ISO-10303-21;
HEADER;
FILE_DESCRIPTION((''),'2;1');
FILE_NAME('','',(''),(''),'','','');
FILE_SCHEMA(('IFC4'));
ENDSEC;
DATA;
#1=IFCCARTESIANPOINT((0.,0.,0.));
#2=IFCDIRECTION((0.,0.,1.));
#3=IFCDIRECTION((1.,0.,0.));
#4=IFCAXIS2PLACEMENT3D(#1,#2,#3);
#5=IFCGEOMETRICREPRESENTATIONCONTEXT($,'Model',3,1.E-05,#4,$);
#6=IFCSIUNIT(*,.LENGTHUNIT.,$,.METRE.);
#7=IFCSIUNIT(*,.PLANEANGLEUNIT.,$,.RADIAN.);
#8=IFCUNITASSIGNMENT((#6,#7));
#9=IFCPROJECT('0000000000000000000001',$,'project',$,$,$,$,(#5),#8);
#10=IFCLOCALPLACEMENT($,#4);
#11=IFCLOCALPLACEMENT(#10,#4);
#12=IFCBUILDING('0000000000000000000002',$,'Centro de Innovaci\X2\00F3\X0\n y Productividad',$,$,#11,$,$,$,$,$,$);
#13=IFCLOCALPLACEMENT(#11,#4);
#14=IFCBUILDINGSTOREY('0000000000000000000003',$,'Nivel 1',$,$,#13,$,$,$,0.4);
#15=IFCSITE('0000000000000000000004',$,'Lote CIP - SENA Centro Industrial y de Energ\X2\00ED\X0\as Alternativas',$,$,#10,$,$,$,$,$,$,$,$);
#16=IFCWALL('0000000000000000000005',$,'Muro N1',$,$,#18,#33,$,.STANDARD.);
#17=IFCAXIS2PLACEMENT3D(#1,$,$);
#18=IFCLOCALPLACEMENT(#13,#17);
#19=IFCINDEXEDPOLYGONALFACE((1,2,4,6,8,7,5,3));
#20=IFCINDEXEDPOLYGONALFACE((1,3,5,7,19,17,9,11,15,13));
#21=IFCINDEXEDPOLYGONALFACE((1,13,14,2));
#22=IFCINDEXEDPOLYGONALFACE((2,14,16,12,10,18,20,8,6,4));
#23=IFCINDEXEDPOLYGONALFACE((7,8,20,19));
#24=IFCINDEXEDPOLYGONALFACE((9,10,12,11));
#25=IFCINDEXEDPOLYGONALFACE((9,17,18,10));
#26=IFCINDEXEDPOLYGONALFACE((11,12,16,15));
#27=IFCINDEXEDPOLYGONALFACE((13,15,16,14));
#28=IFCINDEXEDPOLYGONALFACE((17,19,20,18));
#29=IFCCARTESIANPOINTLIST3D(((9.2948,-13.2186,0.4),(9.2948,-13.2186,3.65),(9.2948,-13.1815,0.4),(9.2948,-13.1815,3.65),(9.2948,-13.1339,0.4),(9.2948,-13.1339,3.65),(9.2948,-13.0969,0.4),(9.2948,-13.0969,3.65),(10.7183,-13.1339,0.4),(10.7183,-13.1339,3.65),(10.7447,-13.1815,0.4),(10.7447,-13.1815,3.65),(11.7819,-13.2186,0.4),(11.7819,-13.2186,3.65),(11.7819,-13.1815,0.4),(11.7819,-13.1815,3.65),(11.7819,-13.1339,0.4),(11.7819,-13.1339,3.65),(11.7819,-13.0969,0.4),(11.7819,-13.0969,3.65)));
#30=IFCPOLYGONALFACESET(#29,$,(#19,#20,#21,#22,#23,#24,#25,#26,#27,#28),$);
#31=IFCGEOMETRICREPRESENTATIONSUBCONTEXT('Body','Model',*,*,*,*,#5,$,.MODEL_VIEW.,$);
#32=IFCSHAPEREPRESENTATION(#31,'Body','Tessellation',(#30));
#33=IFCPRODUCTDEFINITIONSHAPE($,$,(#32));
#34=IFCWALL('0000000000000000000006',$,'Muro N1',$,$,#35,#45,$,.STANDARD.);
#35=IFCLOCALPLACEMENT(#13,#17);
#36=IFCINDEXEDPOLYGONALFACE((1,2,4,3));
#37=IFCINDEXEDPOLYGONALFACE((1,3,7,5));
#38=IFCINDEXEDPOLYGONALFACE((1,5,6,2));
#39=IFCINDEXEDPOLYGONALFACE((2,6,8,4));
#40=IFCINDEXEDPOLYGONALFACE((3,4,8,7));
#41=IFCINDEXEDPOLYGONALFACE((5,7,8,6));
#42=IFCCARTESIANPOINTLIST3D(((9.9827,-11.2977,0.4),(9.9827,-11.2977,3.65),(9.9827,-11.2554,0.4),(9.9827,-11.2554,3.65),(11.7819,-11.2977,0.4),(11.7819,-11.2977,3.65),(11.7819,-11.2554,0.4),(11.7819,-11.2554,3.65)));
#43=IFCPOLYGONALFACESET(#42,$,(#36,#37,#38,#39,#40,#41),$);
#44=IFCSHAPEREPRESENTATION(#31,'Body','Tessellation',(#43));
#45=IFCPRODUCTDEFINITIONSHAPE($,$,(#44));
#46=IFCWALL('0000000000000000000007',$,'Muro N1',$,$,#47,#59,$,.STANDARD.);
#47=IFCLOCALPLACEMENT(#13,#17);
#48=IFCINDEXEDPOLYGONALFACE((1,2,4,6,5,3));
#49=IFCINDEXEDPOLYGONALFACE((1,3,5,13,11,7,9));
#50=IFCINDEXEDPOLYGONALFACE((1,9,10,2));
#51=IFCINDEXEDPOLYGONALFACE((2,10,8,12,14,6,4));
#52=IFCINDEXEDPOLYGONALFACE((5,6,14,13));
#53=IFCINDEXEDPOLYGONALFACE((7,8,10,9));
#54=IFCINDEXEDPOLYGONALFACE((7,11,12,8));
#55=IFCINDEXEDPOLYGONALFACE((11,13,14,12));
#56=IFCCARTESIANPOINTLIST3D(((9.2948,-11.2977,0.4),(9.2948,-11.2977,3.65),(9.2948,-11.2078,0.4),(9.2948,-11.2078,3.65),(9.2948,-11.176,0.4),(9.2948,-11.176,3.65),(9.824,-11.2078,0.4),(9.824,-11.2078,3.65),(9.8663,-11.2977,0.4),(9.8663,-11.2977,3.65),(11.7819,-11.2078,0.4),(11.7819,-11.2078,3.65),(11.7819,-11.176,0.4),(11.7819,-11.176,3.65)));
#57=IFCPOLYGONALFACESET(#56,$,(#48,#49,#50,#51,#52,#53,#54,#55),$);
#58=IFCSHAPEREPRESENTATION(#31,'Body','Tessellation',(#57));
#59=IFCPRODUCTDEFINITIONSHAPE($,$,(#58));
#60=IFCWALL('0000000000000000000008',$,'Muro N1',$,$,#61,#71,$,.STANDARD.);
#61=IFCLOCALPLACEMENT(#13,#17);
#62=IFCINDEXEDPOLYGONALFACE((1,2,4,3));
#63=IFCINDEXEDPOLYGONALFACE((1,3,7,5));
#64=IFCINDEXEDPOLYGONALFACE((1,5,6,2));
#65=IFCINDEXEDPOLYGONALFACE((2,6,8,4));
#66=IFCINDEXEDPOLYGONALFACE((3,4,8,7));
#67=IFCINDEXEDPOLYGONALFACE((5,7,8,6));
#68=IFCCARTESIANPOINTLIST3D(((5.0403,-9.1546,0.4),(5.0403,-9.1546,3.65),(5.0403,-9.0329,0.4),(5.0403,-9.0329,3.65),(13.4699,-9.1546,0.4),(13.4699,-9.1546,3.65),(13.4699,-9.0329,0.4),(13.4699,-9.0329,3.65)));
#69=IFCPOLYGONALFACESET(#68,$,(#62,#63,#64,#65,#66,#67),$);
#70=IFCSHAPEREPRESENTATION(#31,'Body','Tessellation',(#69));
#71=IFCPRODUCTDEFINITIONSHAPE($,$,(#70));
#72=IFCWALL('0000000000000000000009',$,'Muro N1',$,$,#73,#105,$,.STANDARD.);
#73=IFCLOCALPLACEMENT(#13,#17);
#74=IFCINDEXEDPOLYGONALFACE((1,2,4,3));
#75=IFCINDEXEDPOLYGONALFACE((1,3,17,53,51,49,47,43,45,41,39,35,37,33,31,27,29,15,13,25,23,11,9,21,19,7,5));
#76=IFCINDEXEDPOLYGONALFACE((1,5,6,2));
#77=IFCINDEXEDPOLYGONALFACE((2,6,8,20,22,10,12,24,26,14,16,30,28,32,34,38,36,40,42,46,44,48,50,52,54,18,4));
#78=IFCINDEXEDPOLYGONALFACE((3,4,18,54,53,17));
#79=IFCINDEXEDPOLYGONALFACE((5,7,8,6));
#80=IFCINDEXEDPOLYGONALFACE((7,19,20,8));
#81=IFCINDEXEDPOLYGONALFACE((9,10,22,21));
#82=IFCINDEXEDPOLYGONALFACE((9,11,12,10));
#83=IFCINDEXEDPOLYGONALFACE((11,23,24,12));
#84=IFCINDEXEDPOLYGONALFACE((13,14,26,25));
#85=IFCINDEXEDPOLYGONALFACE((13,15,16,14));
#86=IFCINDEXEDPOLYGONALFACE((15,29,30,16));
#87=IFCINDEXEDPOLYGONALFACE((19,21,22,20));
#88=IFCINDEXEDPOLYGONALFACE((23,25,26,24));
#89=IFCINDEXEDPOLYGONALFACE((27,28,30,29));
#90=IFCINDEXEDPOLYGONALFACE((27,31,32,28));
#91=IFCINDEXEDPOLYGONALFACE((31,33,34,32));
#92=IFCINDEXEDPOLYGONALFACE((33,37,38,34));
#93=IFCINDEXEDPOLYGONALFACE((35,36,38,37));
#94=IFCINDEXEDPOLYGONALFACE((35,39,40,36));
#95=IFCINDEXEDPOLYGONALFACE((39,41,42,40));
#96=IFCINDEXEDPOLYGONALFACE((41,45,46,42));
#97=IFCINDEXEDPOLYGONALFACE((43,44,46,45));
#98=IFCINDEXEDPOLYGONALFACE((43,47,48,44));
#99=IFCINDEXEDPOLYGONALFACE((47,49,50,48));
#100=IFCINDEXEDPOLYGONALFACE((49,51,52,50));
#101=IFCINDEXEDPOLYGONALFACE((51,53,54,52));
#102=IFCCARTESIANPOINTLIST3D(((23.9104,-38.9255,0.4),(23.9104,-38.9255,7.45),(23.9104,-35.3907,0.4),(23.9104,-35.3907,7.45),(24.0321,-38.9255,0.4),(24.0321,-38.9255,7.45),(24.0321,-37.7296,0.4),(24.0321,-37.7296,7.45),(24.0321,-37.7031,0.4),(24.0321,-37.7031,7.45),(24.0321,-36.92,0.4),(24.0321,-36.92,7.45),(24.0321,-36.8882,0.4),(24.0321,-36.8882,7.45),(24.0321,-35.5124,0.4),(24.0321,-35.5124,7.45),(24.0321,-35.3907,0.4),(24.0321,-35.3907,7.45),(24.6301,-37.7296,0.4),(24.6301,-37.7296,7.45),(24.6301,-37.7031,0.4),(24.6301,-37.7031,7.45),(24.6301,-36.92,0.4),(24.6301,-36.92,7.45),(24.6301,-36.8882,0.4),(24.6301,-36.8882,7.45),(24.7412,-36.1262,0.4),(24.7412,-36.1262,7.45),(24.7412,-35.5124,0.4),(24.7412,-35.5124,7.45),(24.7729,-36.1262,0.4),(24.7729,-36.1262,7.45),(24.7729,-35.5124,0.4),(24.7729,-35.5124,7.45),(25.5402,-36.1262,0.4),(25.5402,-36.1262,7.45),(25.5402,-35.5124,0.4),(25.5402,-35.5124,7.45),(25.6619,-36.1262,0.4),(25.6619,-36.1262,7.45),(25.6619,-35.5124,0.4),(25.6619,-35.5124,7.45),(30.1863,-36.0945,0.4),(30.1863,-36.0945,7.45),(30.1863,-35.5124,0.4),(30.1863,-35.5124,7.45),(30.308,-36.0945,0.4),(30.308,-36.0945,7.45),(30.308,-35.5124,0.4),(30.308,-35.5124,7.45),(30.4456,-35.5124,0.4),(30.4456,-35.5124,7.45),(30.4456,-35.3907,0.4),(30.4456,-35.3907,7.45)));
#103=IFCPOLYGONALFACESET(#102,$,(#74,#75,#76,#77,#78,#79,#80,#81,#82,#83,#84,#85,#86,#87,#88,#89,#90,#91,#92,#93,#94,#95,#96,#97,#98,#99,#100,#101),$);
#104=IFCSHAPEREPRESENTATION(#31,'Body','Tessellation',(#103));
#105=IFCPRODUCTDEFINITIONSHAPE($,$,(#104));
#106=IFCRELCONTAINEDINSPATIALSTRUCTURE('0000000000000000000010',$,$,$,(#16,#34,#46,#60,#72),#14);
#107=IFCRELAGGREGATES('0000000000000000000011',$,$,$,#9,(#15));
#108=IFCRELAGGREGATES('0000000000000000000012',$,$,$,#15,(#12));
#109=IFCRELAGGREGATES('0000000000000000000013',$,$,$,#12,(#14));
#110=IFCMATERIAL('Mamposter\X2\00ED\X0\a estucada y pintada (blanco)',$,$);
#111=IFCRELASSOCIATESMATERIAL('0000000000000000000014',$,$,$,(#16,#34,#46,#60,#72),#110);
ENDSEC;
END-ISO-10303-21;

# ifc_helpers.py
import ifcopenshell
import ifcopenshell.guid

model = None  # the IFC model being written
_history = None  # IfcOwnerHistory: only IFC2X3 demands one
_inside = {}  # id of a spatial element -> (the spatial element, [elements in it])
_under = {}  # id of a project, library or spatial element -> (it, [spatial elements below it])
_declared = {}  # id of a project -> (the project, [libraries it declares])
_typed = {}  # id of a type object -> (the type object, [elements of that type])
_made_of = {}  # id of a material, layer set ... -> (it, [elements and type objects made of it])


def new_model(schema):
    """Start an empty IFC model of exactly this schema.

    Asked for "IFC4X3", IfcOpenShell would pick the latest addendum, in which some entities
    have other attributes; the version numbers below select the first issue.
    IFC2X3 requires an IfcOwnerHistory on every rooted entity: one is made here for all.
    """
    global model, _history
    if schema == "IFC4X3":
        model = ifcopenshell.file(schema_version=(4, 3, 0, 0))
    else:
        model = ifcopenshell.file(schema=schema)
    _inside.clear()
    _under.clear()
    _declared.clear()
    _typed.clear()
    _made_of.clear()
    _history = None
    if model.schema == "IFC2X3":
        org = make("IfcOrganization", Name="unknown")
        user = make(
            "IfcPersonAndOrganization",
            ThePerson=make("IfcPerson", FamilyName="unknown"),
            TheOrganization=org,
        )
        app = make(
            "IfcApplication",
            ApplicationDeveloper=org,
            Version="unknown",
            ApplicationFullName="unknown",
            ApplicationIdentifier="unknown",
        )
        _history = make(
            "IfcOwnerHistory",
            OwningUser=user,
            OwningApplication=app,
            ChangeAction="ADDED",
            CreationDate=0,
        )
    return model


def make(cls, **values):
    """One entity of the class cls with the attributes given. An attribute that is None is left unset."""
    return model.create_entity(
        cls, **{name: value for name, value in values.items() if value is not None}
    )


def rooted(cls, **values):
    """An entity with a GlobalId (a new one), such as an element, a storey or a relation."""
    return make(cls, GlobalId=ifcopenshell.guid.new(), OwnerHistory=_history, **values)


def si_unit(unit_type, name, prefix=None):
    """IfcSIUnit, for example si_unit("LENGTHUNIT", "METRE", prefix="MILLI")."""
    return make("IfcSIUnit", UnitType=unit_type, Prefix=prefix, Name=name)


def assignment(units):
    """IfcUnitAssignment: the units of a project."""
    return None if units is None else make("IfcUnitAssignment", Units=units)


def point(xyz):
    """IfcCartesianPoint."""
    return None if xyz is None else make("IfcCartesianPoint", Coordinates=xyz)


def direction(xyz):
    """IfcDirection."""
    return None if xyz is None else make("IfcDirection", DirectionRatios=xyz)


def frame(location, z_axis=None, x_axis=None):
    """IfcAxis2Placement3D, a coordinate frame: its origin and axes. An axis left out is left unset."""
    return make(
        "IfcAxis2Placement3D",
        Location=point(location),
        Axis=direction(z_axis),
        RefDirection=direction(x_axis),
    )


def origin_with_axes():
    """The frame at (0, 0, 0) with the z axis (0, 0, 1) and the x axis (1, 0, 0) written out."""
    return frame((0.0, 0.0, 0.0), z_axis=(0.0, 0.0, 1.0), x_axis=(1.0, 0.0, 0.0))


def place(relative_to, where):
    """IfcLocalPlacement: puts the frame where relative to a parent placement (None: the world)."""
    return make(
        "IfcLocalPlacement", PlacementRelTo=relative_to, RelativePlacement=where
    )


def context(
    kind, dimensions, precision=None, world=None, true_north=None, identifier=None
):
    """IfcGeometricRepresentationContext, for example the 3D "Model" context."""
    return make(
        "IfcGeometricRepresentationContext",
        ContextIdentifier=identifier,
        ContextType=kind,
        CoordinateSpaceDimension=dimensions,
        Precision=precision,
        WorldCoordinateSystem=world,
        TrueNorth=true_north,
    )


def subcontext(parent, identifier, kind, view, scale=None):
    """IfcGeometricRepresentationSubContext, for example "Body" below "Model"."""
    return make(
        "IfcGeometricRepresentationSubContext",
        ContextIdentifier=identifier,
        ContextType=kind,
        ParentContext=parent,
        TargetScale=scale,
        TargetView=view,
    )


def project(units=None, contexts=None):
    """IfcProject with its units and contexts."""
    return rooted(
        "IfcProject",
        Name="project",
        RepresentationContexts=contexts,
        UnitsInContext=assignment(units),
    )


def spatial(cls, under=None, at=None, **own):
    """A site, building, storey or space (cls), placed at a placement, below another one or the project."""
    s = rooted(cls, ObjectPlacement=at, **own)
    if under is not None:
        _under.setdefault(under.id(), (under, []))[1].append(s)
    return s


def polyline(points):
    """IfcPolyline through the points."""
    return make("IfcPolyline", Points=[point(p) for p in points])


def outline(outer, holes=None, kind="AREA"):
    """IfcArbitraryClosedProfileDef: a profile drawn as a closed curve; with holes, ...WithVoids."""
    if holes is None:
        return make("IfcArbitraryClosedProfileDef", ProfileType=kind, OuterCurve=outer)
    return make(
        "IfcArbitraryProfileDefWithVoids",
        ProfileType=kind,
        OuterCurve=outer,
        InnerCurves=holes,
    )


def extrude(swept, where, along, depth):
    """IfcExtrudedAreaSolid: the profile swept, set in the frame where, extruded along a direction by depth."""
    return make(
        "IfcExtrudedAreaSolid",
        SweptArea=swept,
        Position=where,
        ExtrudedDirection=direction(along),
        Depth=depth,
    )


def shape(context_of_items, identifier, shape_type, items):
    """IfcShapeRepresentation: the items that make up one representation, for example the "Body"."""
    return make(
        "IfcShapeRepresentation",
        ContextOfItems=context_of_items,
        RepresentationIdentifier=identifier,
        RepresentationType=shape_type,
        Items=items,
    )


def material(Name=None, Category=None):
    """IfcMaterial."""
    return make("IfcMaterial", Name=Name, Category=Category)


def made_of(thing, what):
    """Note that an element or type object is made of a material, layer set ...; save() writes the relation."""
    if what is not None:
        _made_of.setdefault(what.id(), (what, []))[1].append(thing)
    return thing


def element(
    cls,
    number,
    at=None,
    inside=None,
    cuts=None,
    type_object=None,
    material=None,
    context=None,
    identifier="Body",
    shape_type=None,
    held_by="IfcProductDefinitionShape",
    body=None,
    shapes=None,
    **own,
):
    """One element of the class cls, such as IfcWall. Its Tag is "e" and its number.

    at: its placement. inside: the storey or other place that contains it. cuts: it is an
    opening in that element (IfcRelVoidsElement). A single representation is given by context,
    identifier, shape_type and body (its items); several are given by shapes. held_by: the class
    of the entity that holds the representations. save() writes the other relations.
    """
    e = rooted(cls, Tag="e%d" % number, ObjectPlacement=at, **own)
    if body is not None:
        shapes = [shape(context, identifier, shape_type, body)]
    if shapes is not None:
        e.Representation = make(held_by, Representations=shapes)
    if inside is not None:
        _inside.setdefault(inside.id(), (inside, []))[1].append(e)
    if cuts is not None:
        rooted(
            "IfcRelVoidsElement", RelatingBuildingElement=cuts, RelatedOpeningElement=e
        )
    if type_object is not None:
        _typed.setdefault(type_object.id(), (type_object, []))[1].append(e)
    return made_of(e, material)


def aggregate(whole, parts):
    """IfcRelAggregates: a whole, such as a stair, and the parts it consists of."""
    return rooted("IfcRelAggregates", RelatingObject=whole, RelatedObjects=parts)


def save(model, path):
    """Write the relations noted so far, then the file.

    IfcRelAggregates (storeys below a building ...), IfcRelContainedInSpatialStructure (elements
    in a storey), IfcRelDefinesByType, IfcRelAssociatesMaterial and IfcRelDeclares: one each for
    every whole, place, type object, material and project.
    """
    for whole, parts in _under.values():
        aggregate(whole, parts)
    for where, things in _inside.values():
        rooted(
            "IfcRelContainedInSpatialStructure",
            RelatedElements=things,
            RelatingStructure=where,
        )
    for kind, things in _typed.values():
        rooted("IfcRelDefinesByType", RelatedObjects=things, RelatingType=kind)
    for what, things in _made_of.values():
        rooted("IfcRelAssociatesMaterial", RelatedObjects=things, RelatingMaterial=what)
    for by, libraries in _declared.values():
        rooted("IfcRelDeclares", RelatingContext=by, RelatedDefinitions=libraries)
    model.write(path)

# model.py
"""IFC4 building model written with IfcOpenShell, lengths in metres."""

from ifc_helpers import new_model, si_unit, frame, origin_with_axes, place, context, subcontext, project, spatial, polyline, outline, extrude, material, element, save


model = new_model("IFC4")

# Units and contexts
model_context = context("Model", 3, precision=1e-05, world=origin_with_axes())
body_context = subcontext(model_context, "Body", "Model", "MODEL_VIEW")
ifc_project = project(units=[si_unit("LENGTHUNIT", "METRE"), si_unit("PLANEANGLEUNIT", "RADIAN")], contexts=[model_context])

# Site, building, storey
site_placement = place(None, origin_with_axes())
site = spatial("IfcSite", under=ifc_project, at=site_placement, Name="Lote CIP - SENA Centro Industrial y de Energías Alternativas")
building_placement = place(site_placement, origin_with_axes())
building = spatial("IfcBuilding", under=site, at=building_placement, Name="Centro de Innovación y Productividad")
storey_placement = place(building_placement, origin_with_axes())
storey = spatial("IfcBuildingStorey", under=building, at=storey_placement, Name="Nivel 1", Elevation=0.4)

# Walls
ifc_material = material(Name="Mampostería estucada y pintada (blanco)")
wall_1_placement = place(storey_placement, origin_with_axes())
element("IfcWall", 1, at=wall_1_placement, inside=storey, material=ifc_material, Name="Muro N1", PredefinedType="STANDARD", context=body_context, shape_type="SweptSolid", body=[
    extrude(outline(polyline([(11.7819, -13.1815), (11.7819, -13.2186), (9.2948, -13.2186), (9.2948, -13.1815), (9.2948, -13.1339), (9.2948, -13.0969), (11.7819, -13.0969), (11.7819, -13.1339), (10.7183, -13.1339), (10.7447, -13.1815), (11.7819, -13.1815)])), frame((0.0, 0.0, 0.4)), (0.0, 0.0, 1.0), 3.25),
])
wall_2_placement = place(storey_placement, origin_with_axes())
element("IfcWall", 2, at=wall_2_placement, inside=storey, material=ifc_material, Name="Muro N1", PredefinedType="STANDARD", context=body_context, shape_type="SweptSolid", body=[
    extrude(outline(polyline([(11.7819, -11.2977), (9.9827, -11.2977), (9.9827, -11.2554), (11.7819, -11.2554), (11.7819, -11.2977)])), frame((0.0, 0.0, 0.4)), (0.0, 0.0, 1.0), 3.25),
])
wall_3_placement = place(storey_placement, origin_with_axes())
element("IfcWall", 3, at=wall_3_placement, inside=storey, material=ifc_material, Name="Muro N1", PredefinedType="STANDARD", context=body_context, shape_type="SweptSolid", body=[
    extrude(outline(polyline([(9.8663, -11.2977), (9.2948, -11.2977), (9.2948, -11.2078), (9.2948, -11.176), (11.7819, -11.176), (11.7819, -11.2078), (9.824, -11.2078), (9.8663, -11.2977)])), frame((0.0, 0.0, 0.4)), (0.0, 0.0, 1.0), 3.25),
])
wall_4_placement = place(storey_placement, origin_with_axes())
element("IfcWall", 4, at=wall_4_placement, inside=storey, material=ifc_material, Name="Muro N1", PredefinedType="STANDARD", context=body_context, shape_type="SweptSolid", body=[
    extrude(outline(polyline([(5.0403, -9.1546), (5.0403, -9.0329), (13.4699, -9.0329), (13.4699, -9.1546), (5.0403, -9.1546)])), frame((0.0, 0.0, 0.4)), (0.0, 0.0, 1.0), 3.25),
])
wall_5_placement = place(storey_placement, origin_with_axes())
element("IfcWall", 5, at=wall_5_placement, inside=storey, material=ifc_material, Name="Muro N1", PredefinedType="STANDARD", context=body_context, shape_type="SweptSolid", body=[
    extrude(outline(polyline([(24.0321, -36.8882), (24.6301, -36.8882), (24.6301, -36.92), (24.0321, -36.92), (24.0321, -37.7031), (24.6301, -37.7031), (24.6301, -37.7296), (24.0321, -37.7296), (24.0321, -38.9255), (23.9104, -38.9255), (23.9104, -35.3907), (24.0321, -35.3907), (30.4456, -35.3907), (30.4456, -35.5124), (30.308, -35.5124), (30.308, -36.0945), (30.1863, -36.0945), (30.1863, -35.5124), (25.6619, -35.5124), (25.6619, -36.1262), (25.5402, -36.1262), (25.5402, -35.5124), (24.7729, -35.5124), (24.7729, -36.1262), (24.7412, -36.1262), (24.7412, -35.5124), (24.0321, -35.5124), (24.0321, -36.8882)])), frame((0.0, 0.0, 0.4)), (0.0, 0.0, 1.0), 7.05),
])

save(model, "model.ifc")
